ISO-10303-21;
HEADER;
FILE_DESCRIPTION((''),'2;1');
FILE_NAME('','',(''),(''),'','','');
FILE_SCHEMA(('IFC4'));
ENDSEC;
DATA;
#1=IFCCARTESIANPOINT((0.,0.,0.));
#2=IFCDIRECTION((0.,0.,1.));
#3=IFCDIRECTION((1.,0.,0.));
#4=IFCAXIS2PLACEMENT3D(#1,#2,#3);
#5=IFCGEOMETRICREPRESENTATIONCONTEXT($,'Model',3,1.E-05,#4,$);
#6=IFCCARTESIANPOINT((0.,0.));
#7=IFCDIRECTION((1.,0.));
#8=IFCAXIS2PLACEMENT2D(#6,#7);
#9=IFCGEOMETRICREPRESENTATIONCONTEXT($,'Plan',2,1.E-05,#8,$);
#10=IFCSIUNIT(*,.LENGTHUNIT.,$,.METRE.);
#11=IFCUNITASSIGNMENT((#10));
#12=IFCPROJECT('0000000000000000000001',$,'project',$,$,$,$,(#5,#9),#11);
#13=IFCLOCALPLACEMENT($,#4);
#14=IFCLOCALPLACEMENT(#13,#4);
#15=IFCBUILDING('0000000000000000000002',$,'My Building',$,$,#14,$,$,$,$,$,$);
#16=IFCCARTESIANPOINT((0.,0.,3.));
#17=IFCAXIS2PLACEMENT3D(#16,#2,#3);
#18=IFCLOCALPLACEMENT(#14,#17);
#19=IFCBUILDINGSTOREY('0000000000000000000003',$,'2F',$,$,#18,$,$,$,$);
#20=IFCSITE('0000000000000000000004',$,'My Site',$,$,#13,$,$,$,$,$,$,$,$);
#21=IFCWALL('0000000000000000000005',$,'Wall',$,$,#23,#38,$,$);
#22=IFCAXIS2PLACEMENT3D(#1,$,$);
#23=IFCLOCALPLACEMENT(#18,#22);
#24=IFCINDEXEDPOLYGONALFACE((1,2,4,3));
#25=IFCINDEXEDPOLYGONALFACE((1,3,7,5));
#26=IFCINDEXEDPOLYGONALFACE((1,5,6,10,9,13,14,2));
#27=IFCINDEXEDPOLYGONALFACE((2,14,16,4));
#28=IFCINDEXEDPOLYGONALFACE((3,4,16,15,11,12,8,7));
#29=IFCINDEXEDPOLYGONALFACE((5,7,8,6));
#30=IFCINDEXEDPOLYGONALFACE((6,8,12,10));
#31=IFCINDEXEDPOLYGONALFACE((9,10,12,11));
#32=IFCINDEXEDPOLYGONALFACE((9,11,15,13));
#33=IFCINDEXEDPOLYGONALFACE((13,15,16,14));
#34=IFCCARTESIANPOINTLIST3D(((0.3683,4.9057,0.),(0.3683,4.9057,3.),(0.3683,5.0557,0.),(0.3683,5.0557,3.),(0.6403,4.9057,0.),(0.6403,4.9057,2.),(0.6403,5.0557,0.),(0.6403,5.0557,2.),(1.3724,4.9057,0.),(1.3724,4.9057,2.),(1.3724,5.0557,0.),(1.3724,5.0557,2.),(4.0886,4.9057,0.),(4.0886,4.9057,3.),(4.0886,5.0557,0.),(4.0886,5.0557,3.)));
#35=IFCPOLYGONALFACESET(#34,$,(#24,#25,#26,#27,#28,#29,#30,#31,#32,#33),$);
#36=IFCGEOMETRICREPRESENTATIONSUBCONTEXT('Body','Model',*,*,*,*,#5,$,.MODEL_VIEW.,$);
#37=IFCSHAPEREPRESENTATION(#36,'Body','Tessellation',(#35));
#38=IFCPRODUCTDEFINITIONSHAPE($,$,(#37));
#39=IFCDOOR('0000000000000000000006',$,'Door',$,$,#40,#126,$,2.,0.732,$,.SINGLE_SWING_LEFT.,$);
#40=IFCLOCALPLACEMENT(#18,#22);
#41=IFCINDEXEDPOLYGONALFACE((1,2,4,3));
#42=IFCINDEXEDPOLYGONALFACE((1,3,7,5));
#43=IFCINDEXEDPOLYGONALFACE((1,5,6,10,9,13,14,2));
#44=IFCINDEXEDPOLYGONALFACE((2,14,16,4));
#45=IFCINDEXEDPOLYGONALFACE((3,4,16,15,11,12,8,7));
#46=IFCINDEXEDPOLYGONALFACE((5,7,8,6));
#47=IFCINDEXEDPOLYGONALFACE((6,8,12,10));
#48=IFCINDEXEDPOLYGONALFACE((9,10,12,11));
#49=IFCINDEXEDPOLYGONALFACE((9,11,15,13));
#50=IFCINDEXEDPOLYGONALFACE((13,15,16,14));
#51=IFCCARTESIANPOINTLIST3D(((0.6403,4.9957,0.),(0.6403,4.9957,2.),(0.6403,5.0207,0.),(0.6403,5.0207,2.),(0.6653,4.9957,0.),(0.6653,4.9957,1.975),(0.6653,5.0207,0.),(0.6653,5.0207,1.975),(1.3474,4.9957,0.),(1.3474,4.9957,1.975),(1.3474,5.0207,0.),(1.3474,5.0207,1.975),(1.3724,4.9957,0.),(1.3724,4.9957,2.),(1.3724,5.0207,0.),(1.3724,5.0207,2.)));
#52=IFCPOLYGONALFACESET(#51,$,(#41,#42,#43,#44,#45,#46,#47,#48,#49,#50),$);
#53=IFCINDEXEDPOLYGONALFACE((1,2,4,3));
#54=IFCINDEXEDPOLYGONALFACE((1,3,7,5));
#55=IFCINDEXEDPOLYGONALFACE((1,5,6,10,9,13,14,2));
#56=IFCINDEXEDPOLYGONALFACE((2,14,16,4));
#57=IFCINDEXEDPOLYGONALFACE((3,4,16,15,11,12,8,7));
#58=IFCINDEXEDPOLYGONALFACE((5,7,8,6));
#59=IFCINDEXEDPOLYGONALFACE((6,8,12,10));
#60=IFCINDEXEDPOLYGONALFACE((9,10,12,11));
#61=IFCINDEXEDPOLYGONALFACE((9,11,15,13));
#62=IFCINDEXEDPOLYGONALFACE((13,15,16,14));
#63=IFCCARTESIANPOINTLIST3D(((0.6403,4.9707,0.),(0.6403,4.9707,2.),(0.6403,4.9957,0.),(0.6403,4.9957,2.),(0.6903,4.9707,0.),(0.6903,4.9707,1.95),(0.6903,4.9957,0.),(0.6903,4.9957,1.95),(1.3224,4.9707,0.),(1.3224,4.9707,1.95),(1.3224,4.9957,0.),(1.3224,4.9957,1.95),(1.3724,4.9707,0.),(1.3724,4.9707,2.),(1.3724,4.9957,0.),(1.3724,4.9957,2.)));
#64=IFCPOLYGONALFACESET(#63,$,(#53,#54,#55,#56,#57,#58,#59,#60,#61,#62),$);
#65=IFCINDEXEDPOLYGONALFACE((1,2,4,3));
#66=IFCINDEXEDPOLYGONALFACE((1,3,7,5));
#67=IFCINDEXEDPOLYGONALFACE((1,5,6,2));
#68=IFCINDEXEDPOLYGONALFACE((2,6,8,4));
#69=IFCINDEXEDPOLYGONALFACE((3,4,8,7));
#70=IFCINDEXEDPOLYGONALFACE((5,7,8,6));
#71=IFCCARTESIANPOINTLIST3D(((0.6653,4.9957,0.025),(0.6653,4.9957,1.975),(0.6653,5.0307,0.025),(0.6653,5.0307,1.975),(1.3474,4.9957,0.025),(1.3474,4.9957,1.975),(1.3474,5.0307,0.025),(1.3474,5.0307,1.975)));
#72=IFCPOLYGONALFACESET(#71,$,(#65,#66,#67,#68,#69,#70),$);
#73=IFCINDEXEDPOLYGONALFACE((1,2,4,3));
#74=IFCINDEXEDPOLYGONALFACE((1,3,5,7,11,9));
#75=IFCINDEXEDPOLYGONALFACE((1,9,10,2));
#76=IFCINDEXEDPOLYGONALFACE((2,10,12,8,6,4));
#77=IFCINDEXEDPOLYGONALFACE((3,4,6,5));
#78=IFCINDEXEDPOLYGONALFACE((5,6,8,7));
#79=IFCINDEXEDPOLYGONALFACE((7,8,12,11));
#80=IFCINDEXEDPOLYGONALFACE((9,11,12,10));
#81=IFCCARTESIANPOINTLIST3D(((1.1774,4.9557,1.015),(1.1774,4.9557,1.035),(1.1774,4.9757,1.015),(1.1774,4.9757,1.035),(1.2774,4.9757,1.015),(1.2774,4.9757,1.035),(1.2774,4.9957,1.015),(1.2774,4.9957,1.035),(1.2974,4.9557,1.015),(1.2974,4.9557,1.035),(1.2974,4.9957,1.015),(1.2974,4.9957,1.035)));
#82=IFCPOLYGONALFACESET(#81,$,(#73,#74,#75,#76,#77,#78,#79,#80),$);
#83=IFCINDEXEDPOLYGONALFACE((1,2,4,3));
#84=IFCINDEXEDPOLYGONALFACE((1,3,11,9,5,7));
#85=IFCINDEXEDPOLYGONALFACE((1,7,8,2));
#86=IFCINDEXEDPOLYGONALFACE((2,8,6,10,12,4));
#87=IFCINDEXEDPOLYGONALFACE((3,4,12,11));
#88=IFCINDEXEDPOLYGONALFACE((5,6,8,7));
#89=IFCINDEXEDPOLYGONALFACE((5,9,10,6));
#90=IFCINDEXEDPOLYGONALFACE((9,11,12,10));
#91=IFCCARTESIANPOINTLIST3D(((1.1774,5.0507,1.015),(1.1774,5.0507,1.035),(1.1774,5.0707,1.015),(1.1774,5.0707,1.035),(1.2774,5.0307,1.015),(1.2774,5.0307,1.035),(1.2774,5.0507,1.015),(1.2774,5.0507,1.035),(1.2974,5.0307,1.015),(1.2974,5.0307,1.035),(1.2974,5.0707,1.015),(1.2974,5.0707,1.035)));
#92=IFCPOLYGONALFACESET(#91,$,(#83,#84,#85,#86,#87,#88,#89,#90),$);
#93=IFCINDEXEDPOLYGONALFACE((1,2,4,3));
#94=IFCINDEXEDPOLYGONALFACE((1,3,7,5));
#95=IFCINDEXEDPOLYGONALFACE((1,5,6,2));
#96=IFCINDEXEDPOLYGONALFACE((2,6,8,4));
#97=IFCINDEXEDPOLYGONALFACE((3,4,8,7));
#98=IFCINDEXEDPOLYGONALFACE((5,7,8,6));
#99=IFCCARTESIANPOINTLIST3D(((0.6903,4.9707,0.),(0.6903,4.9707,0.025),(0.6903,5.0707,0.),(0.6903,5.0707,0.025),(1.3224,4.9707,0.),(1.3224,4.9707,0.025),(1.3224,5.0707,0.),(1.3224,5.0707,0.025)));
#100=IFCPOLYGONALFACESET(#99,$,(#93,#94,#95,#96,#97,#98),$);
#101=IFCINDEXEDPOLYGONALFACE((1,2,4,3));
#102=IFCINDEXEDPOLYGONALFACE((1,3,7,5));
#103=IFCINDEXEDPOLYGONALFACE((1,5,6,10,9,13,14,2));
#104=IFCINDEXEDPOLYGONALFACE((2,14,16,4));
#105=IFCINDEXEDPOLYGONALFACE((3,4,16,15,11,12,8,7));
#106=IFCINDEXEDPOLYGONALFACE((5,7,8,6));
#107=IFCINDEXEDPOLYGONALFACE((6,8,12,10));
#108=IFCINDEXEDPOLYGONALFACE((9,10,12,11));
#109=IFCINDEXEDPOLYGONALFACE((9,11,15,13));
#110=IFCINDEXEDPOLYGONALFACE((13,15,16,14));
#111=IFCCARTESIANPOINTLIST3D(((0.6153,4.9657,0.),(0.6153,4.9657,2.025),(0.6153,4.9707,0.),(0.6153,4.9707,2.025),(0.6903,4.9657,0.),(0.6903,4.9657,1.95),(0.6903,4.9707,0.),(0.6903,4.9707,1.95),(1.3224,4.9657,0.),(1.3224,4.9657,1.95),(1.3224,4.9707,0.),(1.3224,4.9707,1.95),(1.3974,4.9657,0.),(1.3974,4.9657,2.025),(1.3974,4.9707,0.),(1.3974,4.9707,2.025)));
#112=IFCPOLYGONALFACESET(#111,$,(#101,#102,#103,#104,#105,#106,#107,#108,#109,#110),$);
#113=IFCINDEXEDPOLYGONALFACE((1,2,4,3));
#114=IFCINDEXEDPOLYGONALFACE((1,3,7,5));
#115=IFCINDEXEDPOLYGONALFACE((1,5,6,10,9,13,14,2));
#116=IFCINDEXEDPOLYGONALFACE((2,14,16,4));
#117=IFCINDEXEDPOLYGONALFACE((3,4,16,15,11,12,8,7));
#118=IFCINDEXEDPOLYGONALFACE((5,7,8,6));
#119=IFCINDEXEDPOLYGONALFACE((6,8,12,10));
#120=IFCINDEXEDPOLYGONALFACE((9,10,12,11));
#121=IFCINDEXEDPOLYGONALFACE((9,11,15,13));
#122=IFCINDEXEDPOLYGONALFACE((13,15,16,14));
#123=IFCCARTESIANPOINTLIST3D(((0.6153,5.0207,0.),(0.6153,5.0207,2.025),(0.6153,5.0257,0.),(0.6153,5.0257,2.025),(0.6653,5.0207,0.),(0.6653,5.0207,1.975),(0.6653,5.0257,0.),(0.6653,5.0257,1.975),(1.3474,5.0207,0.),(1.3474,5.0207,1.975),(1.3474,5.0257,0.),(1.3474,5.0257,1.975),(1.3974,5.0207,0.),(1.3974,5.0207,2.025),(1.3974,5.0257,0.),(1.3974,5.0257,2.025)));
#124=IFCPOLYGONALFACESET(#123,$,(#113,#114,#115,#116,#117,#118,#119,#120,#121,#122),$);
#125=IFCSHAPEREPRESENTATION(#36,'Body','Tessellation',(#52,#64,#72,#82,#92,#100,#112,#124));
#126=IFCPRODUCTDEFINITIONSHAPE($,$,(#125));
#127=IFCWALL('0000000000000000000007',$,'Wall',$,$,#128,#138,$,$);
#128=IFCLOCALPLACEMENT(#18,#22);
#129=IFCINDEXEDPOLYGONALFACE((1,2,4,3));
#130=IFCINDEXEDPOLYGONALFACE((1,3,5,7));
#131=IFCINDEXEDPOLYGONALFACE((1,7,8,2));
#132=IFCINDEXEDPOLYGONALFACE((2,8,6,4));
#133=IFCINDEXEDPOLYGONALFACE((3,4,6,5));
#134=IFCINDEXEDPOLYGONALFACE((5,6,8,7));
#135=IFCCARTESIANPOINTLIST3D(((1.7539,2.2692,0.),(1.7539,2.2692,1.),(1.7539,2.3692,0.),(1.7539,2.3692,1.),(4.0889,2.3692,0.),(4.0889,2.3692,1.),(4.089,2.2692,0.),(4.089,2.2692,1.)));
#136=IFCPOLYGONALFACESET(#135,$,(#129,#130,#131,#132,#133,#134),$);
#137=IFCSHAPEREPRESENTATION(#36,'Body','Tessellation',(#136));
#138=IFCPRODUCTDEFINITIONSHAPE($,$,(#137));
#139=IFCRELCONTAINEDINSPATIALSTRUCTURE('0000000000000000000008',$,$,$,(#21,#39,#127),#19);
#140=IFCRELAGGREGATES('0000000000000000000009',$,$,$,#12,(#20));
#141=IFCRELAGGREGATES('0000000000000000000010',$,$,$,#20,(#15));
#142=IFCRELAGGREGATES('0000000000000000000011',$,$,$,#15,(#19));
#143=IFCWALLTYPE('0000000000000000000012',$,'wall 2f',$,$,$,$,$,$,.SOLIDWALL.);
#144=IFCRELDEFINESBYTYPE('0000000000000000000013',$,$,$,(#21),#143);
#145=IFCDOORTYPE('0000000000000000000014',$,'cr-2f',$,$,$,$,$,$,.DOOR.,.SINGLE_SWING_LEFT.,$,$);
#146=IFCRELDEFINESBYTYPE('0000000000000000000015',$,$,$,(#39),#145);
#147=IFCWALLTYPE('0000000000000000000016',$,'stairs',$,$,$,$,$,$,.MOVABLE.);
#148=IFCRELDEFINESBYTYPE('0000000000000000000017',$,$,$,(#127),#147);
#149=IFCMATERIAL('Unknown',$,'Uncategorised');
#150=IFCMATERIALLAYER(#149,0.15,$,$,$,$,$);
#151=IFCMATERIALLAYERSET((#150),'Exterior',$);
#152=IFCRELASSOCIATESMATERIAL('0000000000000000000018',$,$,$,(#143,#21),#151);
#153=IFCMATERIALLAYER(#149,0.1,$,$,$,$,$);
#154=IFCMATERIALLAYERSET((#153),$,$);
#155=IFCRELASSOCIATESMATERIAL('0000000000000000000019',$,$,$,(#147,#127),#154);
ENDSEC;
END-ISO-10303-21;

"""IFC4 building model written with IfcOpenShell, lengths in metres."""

from ifc_helpers import new_model, entity, si_unit, frame, origin_with_axes, origin_2d_with_axis, place, context, subcontext, project, spatial, line, indexed_curve, outline, extrude, shape, source, transform, mapped, material, layer, layer_set, layer_usage, type_object, type_shapes, element, fill, save


model = new_model("IFC4")

# Units and contexts
model_context = context("Model", 3, precision=1e-05, world=origin_with_axes())
plan_context = context("Plan", 2, precision=1e-05, world=origin_2d_with_axis())
body_context_1 = subcontext(model_context, "Body", "Model", "MODEL_VIEW")
body_context_2 = subcontext(plan_context, "Body", "Plan", "PLAN_VIEW")
ifc_project = project(units=[si_unit("LENGTHUNIT", "METRE")], contexts=[model_context, plan_context])

# Site, building, storey
site_placement = place(None, origin_with_axes())
site = spatial("IfcSite", under=ifc_project, at=site_placement, Name="My Site")
building_placement = place(site_placement, origin_with_axes())
building = spatial("IfcBuilding", under=site, at=building_placement, Name="My Building")
storey_placement = place(building_placement, frame((0.0, 0.0, 3.0), z_axis=(0.0, 0.0, 1.0), x_axis=(1.0, 0.0, 0.0)))
storey = spatial("IfcBuildingStorey", under=building, at=storey_placement, Name="2F")

# Shared definitions
ifc_material = material(Name="Unknown", Category="Uncategorised")

# Shared definitions
ifc_layer_1 = layer(ifc_material, 0.15)
ifc_layer_set_1 = layer_set([ifc_layer_1], Name="Exterior")
wall_type_1 = type_object("IfcWallType", Name="wall 2f", PredefinedType="SOLIDWALL", material=ifc_layer_set_1)

# Wall, opening, door
ifc_layer_usage_1 = layer_usage(ifc_layer_set_1, "AXIS2", "POSITIVE", 0.0)
wall_1_placement = place(storey_placement, frame((0.3683, 4.9057, 0.0), z_axis=(0.0, 0.0, 1.0), x_axis=(1.0, 0.0, 0.0)))
wall_1 = element("IfcWall", 1, at=wall_1_placement, inside=storey, type_object=wall_type_1, material=ifc_layer_usage_1, Name="Wall", context=body_context_1, shape_type="SweptSolid", body=[
    extrude(outline(indexed_curve([(0.0, 0.0), (0.0, 0.15), (3.7202, 0.15), (3.7202, 0.0)], segments=[line(1, 2, 3, 4, 1)])), origin_with_axes(), (0.0, 0.0, 1.0), 3.0),
])
shared_shape_1 = source(origin_with_axes(), body_context_1, "Body", "SweptSolid", [
    extrude(outline(indexed_curve([(0.0, 0.0), (0.732, 0.0), (0.732, 2.0), (0.0, 2.0)], segments=[line(1, 2, 3, 4, 1)])), frame((0.0, -0.6, 0.0), z_axis=(0.0, -1.0, 0.0), x_axis=(1.0, 0.0, 0.0)), (0.0, 0.0, -1.0), 1.2),
])
opening_1_placement = place(wall_1_placement, frame((0.272, 0.065, 0.0), z_axis=(0.0, 0.0, 1.0), x_axis=(1.0, 0.0, 0.0)))
opening_1 = element("IfcOpeningElement", 2, at=opening_1_placement, cuts=wall_1, PredefinedType="OPENING", context=body_context_1, shape_type="MappedRepresentation", body=[
    mapped(shared_shape_1, transform((0.0, 0.0, 0.0), x_axis=(1.0, 0.0, 0.0), y_axis=(0.0, 1.0, 0.0), z_axis=(0.0, 0.0, 1.0), scale=1.0)),
])
door_type_1 = type_object("IfcDoorType", Name="cr-2f", OperationType="SINGLE_SWING_LEFT", PredefinedType="DOOR")
shared_shape_2 = source(origin_with_axes(), body_context_1, "Body", "SweptSolid", [
    extrude(outline(indexed_curve([(0.0, 0.0), (0.0, 2.0), (0.732, 2.0), (0.732, 0.0), (0.707, 0.0), (0.707, 1.975), (0.025, 1.975), (0.025, 0.0)], segments=[line(1, 2, 3, 4, 5, 6, 7, 8, 1)])), frame((0.0, 0.025, 0.0), z_axis=(0.0, -1.0, 0.0), x_axis=(1.0, 0.0, 0.0)), (0.0, 0.0, -1.0), 0.025),
    extrude(outline(indexed_curve([(0.0, 0.0), (0.0, 2.0), (0.732, 2.0), (0.732, 0.0), (0.682, 0.0), (0.682, 1.95), (0.05, 1.95), (0.05, 0.0)], segments=[line(1, 2, 3, 4, 5, 6, 7, 8, 1)])), frame((0.0, 0.0, 0.0), z_axis=(0.0, -1.0, 0.0), x_axis=(1.0, 0.0, 0.0)), (0.0, 0.0, -1.0), 0.025),
    extrude(outline(indexed_curve([(0.0, 0.0), (0.682, 0.0), (0.682, 0.035), (0.0, 0.035)], segments=[line(1, 2, 3, 4, 1)])), frame((0.025, 0.025, 0.025), z_axis=(0.0, 0.0, 1.0), x_axis=(1.0, 0.0, 0.0)), (0.0, 0.0, 1.0), 1.95),
    extrude(outline(indexed_curve([(0.0, 0.0), (0.0, -0.04), (-0.12, -0.04), (-0.12, -0.02), (-0.02, -0.02), (-0.02, 0.0)], segments=[line(1, 2, 3, 4, 5, 6, 1)])), frame((0.657, 0.025, 1.015), z_axis=(0.0, 0.0, 1.0), x_axis=(1.0, 0.0, 0.0)), (0.0, 0.0, 1.0), 0.02),
    extrude(outline(indexed_curve([(0.0, 0.0), (0.0, 0.04), (-0.12, 0.04), (-0.12, 0.02), (-0.02, 0.02), (-0.02, 0.0)], segments=[line(1, 2, 3, 4, 5, 6, 1)])), frame((0.657, 0.06, 1.015), z_axis=(0.0, 0.0, 1.0), x_axis=(1.0, 0.0, 0.0)), (0.0, 0.0, 1.0), 0.02),
    extrude(outline(indexed_curve([(0.0, 0.0), (0.632, 0.0), (0.632, 0.1), (0.0, 0.1)], segments=[line(1, 2, 3, 4, 1)])), frame((0.05, 0.0, 0.0), z_axis=(0.0, 0.0, 1.0), x_axis=(1.0, 0.0, 0.0)), (0.0, 0.0, 1.0), 0.025),
    extrude(outline(indexed_curve([(0.0, 0.0), (0.0, 2.025), (0.782, 2.025), (0.782, 0.0), (0.707, 0.0), (0.707, 1.95), (0.075, 1.95), (0.075, 0.0)], segments=[line(1, 2, 3, 4, 5, 6, 7, 8, 1)])), frame((-0.025, -0.005, 0.0), z_axis=(0.0, -1.0, 0.0), x_axis=(1.0, 0.0, 0.0)), (0.0, 0.0, -1.0), 0.005),
    extrude(outline(indexed_curve([(0.0, 0.0), (0.0, 2.025), (0.782, 2.025), (0.782, 0.0), (0.732, 0.0), (0.732, 1.975), (0.05, 1.975), (0.05, 0.0)], segments=[line(1, 2, 3, 4, 5, 6, 7, 8, 1)])), frame((-0.025, 0.05, 0.0), z_axis=(0.0, -1.0, 0.0), x_axis=(1.0, 0.0, 0.0)), (0.0, 0.0, -1.0), 0.005),
])
shared_shape_3 = source(origin_with_axes(), body_context_2, "Body", "Curve2D", [
    entity("IfcIndexedPolyCurve", entity("IfcCartesianPointList2D", [[0.0, 0.0], [0.0, 0.05], [0.025, 0.05], [0.025, 0.025], [0.05, 0.025], [0.05, 0.0]]), [entity("IfcLineIndex", [1, 2, 3, 4, 5, 6, 1])]),
    entity("IfcIndexedPolyCurve", entity("IfcCartesianPointList2D", [[0.732, 0.0], [0.732, 0.05], [0.707, 0.05], [0.707, 0.025], [0.682, 0.025], [0.682, 0.0]]), [entity("IfcLineIndex", [1, 2, 3, 4, 5, 6, 1])]),
    entity("IfcTrimmedCurve", entity("IfcEllipse", entity("IfcAxis2Placement2D", entity("IfcCartesianPoint", [0.06, 0.05]), entity("IfcDirection", [1.0, 0.0])), 0.647, 0.682), [entity("IfcCartesianPoint", [0.707, 0.05])], [entity("IfcCartesianPoint", [0.06, 0.732])], True, "CARTESIAN"),
    entity("IfcIndexedPolyCurve", entity("IfcCartesianPointList2D", [[0.025, 0.05], [0.06, 0.05], [0.06, 0.732], [0.025, 0.732]]), [entity("IfcLineIndex", [1, 2, 3, 4, 1])]),
])
type_shapes(door_type_1, [shared_shape_2, shared_shape_3])
door_1_placement = place(opening_1_placement, frame((0.0, 0.0, 0.0), z_axis=(0.0, 0.0, 1.0), x_axis=(1.0, 0.0, 0.0)))
door_1 = element("IfcDoor", 3, at=door_1_placement, inside=storey, type_object=door_type_1, Name="Door", OperationType="SINGLE_SWING_LEFT", OverallHeight=2.0, OverallWidth=0.732, shapes=[
    shape(body_context_1, "Body", "MappedRepresentation", [mapped(shared_shape_2, transform((0.0, 0.0, 0.0), x_axis=(1.0, 0.0, 0.0), y_axis=(0.0, 1.0, 0.0), z_axis=(0.0, 0.0, 1.0), scale=1.0))]),
    shape(body_context_2, "Body", "MappedRepresentation", [mapped(shared_shape_3, transform((0.0, 0.0, 0.0), x_axis=(1.0, 0.0, 0.0), y_axis=(0.0, 1.0, 0.0), z_axis=(0.0, 0.0, 1.0), scale=1.0))]),
])
fill(opening_1, door_1)

# Wall
ifc_layer_2 = layer(ifc_material, 0.1)
ifc_layer_set_2 = layer_set([ifc_layer_2])
ifc_layer_usage_2 = layer_usage(ifc_layer_set_2, "AXIS2", "POSITIVE", 0.0)
wall_type_2 = type_object("IfcWallType", Name="stairs", PredefinedType="MOVABLE", material=ifc_layer_set_2)
wall_2_placement = place(storey_placement, frame((1.7539, 2.2692, 0.0), z_axis=(0.0, 0.0, 1.0), x_axis=(1.0, 0.0, 0.0)))
element("IfcWall", 4, at=wall_2_placement, inside=storey, type_object=wall_type_2, material=ifc_layer_usage_2, Name="Wall", context=body_context_1, shape_type="SweptSolid", body=[
    extrude(outline(indexed_curve([(0.0, 0.0), (0.0, 0.1), (2.3351, 0.1), (2.3351, 0.0)], segments=[line(1, 2, 3, 4, 1)])), origin_with_axes(), (0.0, 0.0, 1.0), 1.0),
])

save(model, "model.ifc")
